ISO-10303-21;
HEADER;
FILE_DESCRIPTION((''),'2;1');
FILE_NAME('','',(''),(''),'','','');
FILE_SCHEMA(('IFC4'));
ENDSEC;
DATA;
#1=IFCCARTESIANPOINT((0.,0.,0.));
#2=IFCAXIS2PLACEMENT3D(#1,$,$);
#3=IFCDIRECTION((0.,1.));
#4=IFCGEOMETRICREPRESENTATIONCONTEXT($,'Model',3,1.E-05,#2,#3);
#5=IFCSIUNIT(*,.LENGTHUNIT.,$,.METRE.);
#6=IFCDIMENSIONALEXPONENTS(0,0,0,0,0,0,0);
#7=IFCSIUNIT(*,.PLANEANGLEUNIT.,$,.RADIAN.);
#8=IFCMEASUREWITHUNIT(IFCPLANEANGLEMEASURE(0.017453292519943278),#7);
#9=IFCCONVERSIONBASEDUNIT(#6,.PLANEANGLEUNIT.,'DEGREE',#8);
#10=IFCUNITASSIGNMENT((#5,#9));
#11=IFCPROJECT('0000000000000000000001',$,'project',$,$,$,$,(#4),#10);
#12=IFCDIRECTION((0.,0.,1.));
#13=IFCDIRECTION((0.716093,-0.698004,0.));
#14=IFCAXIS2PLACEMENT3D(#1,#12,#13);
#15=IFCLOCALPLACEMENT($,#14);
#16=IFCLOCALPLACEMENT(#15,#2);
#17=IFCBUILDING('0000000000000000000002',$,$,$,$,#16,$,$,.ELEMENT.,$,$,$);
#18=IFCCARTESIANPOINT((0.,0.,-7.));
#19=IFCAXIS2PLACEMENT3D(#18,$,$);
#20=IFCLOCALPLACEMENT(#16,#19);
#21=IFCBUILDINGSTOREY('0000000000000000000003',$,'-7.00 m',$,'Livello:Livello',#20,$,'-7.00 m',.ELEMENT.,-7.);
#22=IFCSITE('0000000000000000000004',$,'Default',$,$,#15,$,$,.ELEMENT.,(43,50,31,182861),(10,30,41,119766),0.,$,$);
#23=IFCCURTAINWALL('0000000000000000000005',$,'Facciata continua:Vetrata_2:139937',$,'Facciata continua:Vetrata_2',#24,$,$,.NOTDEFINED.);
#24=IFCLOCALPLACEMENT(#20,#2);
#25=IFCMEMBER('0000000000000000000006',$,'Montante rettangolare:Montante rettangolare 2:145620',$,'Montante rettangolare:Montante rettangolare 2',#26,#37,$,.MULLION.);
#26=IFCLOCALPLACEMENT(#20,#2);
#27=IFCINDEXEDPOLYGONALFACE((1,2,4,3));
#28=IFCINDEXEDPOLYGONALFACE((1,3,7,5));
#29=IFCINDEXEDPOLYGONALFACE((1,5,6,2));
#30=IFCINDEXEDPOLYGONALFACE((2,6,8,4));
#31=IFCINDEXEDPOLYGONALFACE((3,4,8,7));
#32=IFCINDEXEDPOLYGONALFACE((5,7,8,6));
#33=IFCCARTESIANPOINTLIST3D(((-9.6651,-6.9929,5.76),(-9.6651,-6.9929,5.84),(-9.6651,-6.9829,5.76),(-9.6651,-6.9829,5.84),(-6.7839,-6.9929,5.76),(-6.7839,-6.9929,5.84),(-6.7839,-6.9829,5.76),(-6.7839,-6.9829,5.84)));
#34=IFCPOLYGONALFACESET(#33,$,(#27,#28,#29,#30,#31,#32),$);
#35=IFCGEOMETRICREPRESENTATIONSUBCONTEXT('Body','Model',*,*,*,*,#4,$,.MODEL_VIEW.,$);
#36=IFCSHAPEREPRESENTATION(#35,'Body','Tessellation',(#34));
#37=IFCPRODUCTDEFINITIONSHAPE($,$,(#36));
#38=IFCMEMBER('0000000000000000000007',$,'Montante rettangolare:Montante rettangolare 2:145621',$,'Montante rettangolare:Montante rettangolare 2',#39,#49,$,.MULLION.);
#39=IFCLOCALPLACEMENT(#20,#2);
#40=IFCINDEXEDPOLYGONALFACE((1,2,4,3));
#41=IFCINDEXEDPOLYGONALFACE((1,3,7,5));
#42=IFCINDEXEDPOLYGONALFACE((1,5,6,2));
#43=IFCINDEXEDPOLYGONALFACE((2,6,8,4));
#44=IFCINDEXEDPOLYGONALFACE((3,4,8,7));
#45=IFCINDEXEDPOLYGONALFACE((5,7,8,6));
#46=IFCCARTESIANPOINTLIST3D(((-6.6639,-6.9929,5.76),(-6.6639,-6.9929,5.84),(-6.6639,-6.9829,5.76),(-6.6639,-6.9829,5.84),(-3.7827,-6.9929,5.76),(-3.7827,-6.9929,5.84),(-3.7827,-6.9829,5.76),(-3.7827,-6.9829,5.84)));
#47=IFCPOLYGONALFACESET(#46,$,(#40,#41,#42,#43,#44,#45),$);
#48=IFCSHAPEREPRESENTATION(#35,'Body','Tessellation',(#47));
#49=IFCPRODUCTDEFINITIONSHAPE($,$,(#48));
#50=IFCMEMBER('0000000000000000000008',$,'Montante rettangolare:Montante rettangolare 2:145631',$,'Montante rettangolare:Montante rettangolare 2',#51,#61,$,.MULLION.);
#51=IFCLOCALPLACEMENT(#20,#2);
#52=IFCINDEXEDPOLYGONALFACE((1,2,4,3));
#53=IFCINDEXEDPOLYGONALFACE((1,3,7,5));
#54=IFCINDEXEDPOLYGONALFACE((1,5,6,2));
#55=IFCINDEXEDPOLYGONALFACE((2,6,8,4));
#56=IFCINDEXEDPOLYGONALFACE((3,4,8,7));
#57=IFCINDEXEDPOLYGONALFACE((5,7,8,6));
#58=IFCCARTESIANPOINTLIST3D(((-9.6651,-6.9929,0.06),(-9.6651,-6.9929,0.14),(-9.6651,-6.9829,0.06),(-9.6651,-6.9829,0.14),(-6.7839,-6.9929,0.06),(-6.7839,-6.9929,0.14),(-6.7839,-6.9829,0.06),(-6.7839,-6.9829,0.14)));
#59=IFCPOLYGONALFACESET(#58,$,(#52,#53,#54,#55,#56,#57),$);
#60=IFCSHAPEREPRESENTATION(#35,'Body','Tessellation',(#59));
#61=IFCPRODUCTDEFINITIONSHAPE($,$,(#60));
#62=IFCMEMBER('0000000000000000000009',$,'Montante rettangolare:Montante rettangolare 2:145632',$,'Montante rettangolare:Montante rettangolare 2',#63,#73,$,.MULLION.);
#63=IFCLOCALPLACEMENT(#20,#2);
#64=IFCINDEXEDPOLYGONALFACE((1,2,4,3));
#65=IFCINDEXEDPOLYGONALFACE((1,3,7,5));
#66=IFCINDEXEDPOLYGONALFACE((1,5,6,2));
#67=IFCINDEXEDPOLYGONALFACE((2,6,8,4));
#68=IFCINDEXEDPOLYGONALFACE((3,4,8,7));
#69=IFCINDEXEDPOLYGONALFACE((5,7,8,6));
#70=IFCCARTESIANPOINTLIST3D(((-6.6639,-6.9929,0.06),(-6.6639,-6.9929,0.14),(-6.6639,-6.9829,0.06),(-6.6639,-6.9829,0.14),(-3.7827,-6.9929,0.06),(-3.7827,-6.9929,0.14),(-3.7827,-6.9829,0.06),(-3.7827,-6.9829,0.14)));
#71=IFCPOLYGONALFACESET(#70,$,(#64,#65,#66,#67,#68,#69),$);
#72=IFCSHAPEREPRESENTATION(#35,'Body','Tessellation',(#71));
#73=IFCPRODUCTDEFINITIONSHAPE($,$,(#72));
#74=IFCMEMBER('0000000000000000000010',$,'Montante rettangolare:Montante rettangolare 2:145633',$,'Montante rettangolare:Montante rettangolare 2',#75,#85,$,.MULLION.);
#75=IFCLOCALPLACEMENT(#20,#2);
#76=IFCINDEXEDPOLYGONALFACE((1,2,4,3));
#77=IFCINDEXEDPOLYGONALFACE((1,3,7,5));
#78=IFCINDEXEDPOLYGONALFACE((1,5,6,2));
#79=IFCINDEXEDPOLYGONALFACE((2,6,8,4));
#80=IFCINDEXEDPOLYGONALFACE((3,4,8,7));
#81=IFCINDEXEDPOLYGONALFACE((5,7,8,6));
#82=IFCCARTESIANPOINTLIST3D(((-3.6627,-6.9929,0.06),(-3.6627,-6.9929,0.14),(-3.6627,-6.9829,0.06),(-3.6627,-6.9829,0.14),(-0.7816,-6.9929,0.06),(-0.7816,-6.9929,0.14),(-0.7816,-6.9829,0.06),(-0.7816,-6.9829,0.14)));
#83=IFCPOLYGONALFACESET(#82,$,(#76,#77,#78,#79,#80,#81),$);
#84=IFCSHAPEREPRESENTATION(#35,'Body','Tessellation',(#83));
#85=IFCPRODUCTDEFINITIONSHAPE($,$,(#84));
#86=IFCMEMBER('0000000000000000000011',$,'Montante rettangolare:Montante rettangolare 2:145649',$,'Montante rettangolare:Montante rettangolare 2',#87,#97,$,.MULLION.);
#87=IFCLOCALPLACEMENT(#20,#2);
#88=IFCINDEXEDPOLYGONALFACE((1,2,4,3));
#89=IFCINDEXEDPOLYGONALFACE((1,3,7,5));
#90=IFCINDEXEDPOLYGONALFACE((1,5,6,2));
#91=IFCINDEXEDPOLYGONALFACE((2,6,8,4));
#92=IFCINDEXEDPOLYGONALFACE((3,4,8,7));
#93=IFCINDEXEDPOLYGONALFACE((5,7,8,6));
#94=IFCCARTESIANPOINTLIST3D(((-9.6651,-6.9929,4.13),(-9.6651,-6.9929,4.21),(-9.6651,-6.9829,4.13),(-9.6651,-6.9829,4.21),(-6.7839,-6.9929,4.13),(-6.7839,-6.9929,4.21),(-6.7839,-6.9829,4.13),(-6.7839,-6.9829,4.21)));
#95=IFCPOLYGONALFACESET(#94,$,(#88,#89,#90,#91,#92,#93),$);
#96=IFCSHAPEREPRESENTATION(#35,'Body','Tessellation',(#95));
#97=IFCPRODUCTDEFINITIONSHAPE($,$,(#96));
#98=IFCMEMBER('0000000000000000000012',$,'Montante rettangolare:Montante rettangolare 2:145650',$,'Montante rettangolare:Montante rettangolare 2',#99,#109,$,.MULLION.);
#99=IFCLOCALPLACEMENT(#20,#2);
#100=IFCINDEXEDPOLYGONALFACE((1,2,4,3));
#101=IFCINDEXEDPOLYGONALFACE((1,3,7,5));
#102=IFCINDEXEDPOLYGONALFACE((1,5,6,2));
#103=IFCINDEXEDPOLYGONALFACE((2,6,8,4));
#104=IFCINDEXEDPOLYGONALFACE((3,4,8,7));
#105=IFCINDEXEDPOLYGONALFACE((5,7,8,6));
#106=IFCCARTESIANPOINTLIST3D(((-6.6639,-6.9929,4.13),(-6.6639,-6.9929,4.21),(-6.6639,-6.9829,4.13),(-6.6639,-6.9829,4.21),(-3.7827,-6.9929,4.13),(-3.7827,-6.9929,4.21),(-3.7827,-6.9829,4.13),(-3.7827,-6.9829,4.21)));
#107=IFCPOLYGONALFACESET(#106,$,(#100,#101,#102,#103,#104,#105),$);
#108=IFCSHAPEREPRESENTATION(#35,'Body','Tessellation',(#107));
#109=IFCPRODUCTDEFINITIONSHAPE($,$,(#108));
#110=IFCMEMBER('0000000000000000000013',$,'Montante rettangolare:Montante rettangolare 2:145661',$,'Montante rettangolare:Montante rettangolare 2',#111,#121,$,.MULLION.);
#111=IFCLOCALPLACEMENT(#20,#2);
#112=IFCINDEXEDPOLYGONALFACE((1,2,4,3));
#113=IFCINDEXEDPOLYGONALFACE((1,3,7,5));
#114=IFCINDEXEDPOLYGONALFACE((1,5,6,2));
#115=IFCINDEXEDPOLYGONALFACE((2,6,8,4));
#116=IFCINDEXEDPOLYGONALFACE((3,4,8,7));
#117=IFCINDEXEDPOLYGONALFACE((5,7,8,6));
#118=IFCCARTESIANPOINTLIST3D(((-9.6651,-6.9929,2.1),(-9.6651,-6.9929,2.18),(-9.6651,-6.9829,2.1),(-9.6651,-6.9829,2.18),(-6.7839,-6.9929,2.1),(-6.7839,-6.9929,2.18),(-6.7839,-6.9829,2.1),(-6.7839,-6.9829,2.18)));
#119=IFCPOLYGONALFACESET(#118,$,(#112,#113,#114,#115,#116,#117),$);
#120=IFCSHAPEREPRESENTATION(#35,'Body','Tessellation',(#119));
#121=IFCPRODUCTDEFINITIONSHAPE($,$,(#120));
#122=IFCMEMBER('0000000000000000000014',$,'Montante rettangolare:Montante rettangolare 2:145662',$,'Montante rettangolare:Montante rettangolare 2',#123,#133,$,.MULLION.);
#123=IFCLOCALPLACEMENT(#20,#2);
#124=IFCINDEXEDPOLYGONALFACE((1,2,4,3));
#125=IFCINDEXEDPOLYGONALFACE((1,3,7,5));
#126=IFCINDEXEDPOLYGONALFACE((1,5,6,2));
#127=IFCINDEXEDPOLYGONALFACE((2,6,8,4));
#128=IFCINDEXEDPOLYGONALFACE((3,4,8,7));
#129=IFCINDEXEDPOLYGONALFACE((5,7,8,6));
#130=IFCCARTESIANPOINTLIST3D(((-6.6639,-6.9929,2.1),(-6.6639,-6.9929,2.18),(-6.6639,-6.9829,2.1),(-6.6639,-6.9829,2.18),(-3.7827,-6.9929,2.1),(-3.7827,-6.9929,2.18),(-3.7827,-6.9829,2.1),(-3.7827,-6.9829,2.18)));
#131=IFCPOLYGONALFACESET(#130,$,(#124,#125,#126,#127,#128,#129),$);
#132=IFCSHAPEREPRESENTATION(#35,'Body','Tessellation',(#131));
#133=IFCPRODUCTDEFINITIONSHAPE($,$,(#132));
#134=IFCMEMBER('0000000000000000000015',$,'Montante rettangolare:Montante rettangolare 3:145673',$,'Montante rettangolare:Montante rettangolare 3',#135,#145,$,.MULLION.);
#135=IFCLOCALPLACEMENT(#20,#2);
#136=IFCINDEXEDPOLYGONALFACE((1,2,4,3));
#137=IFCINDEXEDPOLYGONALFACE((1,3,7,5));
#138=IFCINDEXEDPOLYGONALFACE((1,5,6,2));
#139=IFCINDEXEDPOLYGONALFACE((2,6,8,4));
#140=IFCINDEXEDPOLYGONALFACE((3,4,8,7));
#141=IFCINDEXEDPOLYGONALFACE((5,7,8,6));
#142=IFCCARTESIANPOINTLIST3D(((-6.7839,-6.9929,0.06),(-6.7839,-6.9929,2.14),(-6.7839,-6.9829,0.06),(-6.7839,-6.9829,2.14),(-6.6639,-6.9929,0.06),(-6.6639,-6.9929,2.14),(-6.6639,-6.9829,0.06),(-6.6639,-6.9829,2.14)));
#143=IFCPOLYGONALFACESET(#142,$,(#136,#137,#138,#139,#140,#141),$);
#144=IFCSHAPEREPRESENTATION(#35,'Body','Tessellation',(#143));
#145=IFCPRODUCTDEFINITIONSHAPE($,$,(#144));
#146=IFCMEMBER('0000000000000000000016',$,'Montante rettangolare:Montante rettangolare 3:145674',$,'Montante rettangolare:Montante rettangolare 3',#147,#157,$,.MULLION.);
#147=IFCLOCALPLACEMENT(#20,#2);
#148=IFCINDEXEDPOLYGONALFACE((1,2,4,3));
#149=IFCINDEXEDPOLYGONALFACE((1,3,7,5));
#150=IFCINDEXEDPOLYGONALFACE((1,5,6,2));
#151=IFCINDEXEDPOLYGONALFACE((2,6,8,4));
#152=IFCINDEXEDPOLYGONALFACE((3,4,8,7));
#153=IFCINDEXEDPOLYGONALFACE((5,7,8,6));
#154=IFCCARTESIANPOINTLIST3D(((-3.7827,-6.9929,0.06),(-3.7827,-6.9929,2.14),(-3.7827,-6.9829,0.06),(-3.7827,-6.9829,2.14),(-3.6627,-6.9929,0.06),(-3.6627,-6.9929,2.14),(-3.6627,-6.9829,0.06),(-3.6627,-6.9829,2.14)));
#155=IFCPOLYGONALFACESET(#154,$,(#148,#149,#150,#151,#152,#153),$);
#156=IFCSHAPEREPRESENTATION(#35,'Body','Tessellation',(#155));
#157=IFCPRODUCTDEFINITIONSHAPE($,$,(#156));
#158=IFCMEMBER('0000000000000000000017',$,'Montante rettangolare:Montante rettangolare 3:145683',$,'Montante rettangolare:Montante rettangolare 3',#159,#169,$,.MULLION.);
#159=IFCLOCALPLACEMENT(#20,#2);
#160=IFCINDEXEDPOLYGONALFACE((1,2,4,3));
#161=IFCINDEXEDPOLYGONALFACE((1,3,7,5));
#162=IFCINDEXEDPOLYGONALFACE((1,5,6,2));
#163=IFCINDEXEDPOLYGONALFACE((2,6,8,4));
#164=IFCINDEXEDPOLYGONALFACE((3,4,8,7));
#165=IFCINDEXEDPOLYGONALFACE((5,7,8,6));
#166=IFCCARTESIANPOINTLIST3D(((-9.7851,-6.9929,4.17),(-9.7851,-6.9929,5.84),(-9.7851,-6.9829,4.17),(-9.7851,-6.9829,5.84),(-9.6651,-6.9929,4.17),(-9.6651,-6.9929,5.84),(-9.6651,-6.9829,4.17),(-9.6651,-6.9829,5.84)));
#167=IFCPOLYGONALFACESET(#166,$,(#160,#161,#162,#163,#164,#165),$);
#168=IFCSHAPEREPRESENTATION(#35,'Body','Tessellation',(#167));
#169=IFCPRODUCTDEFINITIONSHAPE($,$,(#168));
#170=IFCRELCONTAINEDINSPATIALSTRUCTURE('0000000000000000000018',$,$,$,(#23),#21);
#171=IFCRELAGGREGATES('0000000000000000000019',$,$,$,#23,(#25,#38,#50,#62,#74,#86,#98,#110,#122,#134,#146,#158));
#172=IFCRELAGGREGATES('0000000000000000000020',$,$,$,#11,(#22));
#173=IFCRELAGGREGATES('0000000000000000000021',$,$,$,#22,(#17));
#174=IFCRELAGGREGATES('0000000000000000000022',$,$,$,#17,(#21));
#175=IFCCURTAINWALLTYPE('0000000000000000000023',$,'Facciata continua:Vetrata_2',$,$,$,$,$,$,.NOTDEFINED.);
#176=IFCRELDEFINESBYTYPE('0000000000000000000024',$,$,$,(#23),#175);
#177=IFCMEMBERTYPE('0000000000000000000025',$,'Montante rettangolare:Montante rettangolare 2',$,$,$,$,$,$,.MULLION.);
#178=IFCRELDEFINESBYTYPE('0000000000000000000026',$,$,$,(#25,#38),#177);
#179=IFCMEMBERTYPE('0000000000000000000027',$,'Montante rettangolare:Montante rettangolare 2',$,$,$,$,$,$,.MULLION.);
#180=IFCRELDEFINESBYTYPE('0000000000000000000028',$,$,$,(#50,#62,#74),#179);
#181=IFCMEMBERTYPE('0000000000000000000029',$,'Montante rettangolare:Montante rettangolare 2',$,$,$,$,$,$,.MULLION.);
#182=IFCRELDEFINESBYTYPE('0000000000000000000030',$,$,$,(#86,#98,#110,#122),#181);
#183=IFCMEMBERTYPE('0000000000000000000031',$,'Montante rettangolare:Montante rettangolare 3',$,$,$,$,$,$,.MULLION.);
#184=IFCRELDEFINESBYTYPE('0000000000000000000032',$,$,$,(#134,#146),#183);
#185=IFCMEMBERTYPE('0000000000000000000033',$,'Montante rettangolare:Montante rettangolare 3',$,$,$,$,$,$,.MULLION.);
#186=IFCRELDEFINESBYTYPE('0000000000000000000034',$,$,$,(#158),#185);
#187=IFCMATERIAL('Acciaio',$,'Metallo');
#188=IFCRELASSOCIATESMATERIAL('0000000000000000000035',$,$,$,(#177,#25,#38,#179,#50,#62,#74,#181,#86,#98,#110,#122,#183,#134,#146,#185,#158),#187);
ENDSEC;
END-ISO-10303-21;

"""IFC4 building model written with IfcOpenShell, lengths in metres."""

from ifc_helpers import new_model, entity, si_unit, converted_unit, direction, frame, origin, place, context, subcontext, project, spatial, indexed_curve, outline, extrude, source, transform, mapped, material, type_object, type_shapes, element, aggregate, save


model = new_model("IFC4")

# Units and contexts
model_context = context("Model", 3, precision=1e-05, world=origin(), true_north=direction((0.0, 1.0)))
body_context = subcontext(model_context, "Body", "Model", "MODEL_VIEW")
ifc_project = project(units=[si_unit("LENGTHUNIT", "METRE"), converted_unit("PLANEANGLEUNIT", "DEGREE", entity("IfcPlaneAngleMeasure", 0.017453292519943278), si_unit("PLANEANGLEUNIT", "RADIAN"), dimensions=[0, 0, 0, 0, 0, 0, 0])], contexts=[model_context])

# Site, building, storey
site_placement = place(None, frame((0.0, 0.0, 0.0), z_axis=(0.0, 0.0, 1.0), x_axis=(0.716093, -0.698004, 0.0)))
site = spatial("IfcSite", under=ifc_project, at=site_placement, Name="Default", CompositionType="ELEMENT", RefLatitude=(43, 50, 31, 182861), RefLongitude=(10, 30, 41, 119766), RefElevation=0.0)
building_placement = place(site_placement, origin())
building = spatial("IfcBuilding", under=site, at=building_placement, CompositionType="ELEMENT")
storey_placement = place(building_placement, frame((0.0, 0.0, -7.0)))
storey = spatial("IfcBuildingStorey", under=building, at=storey_placement, Name="-7.00 m", ObjectType="Livello:Livello", LongName="-7.00 m", CompositionType="ELEMENT", Elevation=-7.0)

# Curtain wall, members
curtain_wall_type = type_object("IfcCurtainWallType", Name="Facciata continua:Vetrata_2", PredefinedType="NOTDEFINED")
curtain_wall_placement = place(storey_placement, frame((0.0, 0.0, 7.0)))
curtain_wall = element("IfcCurtainWall", 1, at=curtain_wall_placement, inside=storey, type_object=curtain_wall_type, Name="Facciata continua:Vetrata_2:139937", ObjectType="Facciata continua:Vetrata_2", PredefinedType="NOTDEFINED")
ifc_material_1 = material(Name="Acciaio", Category="Metallo")
member_type_1 = type_object("IfcMemberType", Name="Montante rettangolare:Montante rettangolare 2", PredefinedType="MULLION", material=ifc_material_1)
shared_shape_1 = source(origin(), body_context, "Body", "SweptSolid", [
    extrude(outline(indexed_curve([(-0.04, -0.005), (0.04, -0.005), (0.04, 0.005), (-0.04, 0.005), (-0.04, -0.005)], self_intersect=False)), frame((-0.04, 0.01, -2.8812), z_axis=(0.0, 0.0, 1.0), x_axis=(-1.0, 0.0, 0.0)), (0.0, 0.0, 1.0), 2.8812),
])
type_shapes(member_type_1, [shared_shape_1])
member_1_placement = place(curtain_wall_placement, frame((-6.7839, -6.9779, -1.16), z_axis=(1.0, 0.0, 0.0), x_axis=(0.0, 0.0, 1.0)))
member_1 = element("IfcMember", 2, at=member_1_placement, type_object=member_type_1, material=ifc_material_1, Name="Montante rettangolare:Montante rettangolare 2:145620", ObjectType="Montante rettangolare:Montante rettangolare 2", PredefinedType="MULLION", context=body_context, shape_type="MappedRepresentation", body=[
    mapped(shared_shape_1, transform((0.0, 0.0, 0.0), scale=1.0)),
])
member_2_placement = place(curtain_wall_placement, frame((-3.7827, -6.9779, -1.16), z_axis=(1.0, 0.0, 0.0), x_axis=(0.0, 0.0, 1.0)))
member_2 = element("IfcMember", 3, at=member_2_placement, type_object=member_type_1, material=ifc_material_1, Name="Montante rettangolare:Montante rettangolare 2:145621", ObjectType="Montante rettangolare:Montante rettangolare 2", PredefinedType="MULLION", context=body_context, shape_type="MappedRepresentation", body=[
    mapped(shared_shape_1, transform((0.0, 0.0, 0.0), scale=1.0)),
])
member_type_2 = type_object("IfcMemberType", Name="Montante rettangolare:Montante rettangolare 2", PredefinedType="MULLION", material=ifc_material_1)
shared_shape_2 = source(origin(), body_context, "Body", "SweptSolid", [
    extrude(outline(indexed_curve([(-0.04, -0.005), (0.04, -0.005), (0.04, 0.005), (-0.04, 0.005), (-0.04, -0.005)], self_intersect=False)), frame((-0.04, 0.01, -2.8812), z_axis=(0.0, 0.0, 1.0), x_axis=(-1.0, 0.0, 0.0)), (0.0, 0.0, 1.0), 2.8812),
])
type_shapes(member_type_2, [shared_shape_2])
member_3_placement = place(curtain_wall_placement, frame((-9.6651, -6.9779, -6.94), z_axis=(-1.0, 0.0, 0.0), x_axis=(0.0, 0.0, -1.0)))
member_3 = element("IfcMember", 4, at=member_3_placement, type_object=member_type_2, material=ifc_material_1, Name="Montante rettangolare:Montante rettangolare 2:145631", ObjectType="Montante rettangolare:Montante rettangolare 2", PredefinedType="MULLION", context=body_context, shape_type="MappedRepresentation", body=[
    mapped(shared_shape_2, transform((0.0, 0.0, 0.0), scale=1.0)),
])
member_4_placement = place(curtain_wall_placement, frame((-6.6639, -6.9779, -6.94), z_axis=(-1.0, 0.0, 0.0), x_axis=(0.0, 0.0, -1.0)))
member_4 = element("IfcMember", 5, at=member_4_placement, type_object=member_type_2, material=ifc_material_1, Name="Montante rettangolare:Montante rettangolare 2:145632", ObjectType="Montante rettangolare:Montante rettangolare 2", PredefinedType="MULLION", context=body_context, shape_type="MappedRepresentation", body=[
    mapped(shared_shape_2, transform((0.0, 0.0, 0.0), scale=1.0)),
])
member_5_placement = place(curtain_wall_placement, frame((-3.6627, -6.9779, -6.94), z_axis=(-1.0, 0.0, 0.0), x_axis=(0.0, 0.0, -1.0)))
member_5 = element("IfcMember", 6, at=member_5_placement, type_object=member_type_2, material=ifc_material_1, Name="Montante rettangolare:Montante rettangolare 2:145633", ObjectType="Montante rettangolare:Montante rettangolare 2", PredefinedType="MULLION", context=body_context, shape_type="MappedRepresentation", body=[
    mapped(shared_shape_2, transform((0.0, 0.0, 0.0), scale=1.0)),
])
member_type_3 = type_object("IfcMemberType", Name="Montante rettangolare:Montante rettangolare 2", PredefinedType="MULLION", material=ifc_material_1)
shared_shape_3 = source(origin(), body_context, "Body", "SweptSolid", [
    extrude(outline(indexed_curve([(-0.04, -0.005), (0.04, -0.005), (0.04, 0.005), (-0.04, 0.005), (-0.04, -0.005)], self_intersect=False)), frame((0.0, 0.01, -2.8812), z_axis=(0.0, 0.0, 1.0), x_axis=(-1.0, 0.0, 0.0)), (0.0, 0.0, 1.0), 2.8812),
])
type_shapes(member_type_3, [shared_shape_3])
member_6_placement = place(curtain_wall_placement, frame((-6.7839, -6.9779, -2.83), z_axis=(1.0, 0.0, 0.0), x_axis=(0.0, 0.0, 1.0)))
member_6 = element("IfcMember", 7, at=member_6_placement, type_object=member_type_3, material=ifc_material_1, Name="Montante rettangolare:Montante rettangolare 2:145649", ObjectType="Montante rettangolare:Montante rettangolare 2", PredefinedType="MULLION", context=body_context, shape_type="MappedRepresentation", body=[
    mapped(shared_shape_3, transform((0.0, 0.0, 0.0), scale=1.0)),
])
member_7_placement = place(curtain_wall_placement, frame((-3.7827, -6.9779, -2.83), z_axis=(1.0, 0.0, 0.0), x_axis=(0.0, 0.0, 1.0)))
member_7 = element("IfcMember", 8, at=member_7_placement, type_object=member_type_3, material=ifc_material_1, Name="Montante rettangolare:Montante rettangolare 2:145650", ObjectType="Montante rettangolare:Montante rettangolare 2", PredefinedType="MULLION", context=body_context, shape_type="MappedRepresentation", body=[
    mapped(shared_shape_3, transform((0.0, 0.0, 0.0), scale=1.0)),
])
member_8_placement = place(curtain_wall_placement, frame((-6.7839, -6.9779, -4.86), z_axis=(1.0, 0.0, 0.0), x_axis=(0.0, 0.0, 1.0)))
member_8 = element("IfcMember", 9, at=member_8_placement, type_object=member_type_3, material=ifc_material_1, Name="Montante rettangolare:Montante rettangolare 2:145661", ObjectType="Montante rettangolare:Montante rettangolare 2", PredefinedType="MULLION", context=body_context, shape_type="MappedRepresentation", body=[
    mapped(shared_shape_3, transform((0.0, 0.0, 0.0), scale=1.0)),
])
member_9_placement = place(curtain_wall_placement, frame((-3.7827, -6.9779, -4.86), z_axis=(1.0, 0.0, 0.0), x_axis=(0.0, 0.0, 1.0)))
member_9 = element("IfcMember", 10, at=member_9_placement, type_object=member_type_3, material=ifc_material_1, Name="Montante rettangolare:Montante rettangolare 2:145662", ObjectType="Montante rettangolare:Montante rettangolare 2", PredefinedType="MULLION", context=body_context, shape_type="MappedRepresentation", body=[
    mapped(shared_shape_3, transform((0.0, 0.0, 0.0), scale=1.0)),
])
member_type_4 = type_object("IfcMemberType", Name="Montante rettangolare:Montante rettangolare 3", PredefinedType="MULLION", material=ifc_material_1)
shared_shape_4 = source(origin(), body_context, "Body", "SweptSolid", [
    extrude(outline(indexed_curve([(-0.06, -0.005), (0.06, -0.005), (0.06, 0.005), (-0.06, 0.005), (-0.06, -0.005)], self_intersect=False)), frame((0.0, 0.01, -2.08), z_axis=(0.0, 0.0, 1.0), x_axis=(-1.0, 0.0, 0.0)), (0.0, 0.0, 1.0), 2.08),
])
type_shapes(member_type_4, [shared_shape_4])
member_10_placement = place(curtain_wall_placement, frame((-6.7239, -6.9779, -6.94), z_axis=(0.0, 0.0, -1.0), x_axis=(1.0, 0.0, 0.0)))
member_10 = element("IfcMember", 11, at=member_10_placement, type_object=member_type_4, material=ifc_material_1, Name="Montante rettangolare:Montante rettangolare 3:145673", ObjectType="Montante rettangolare:Montante rettangolare 3", PredefinedType="MULLION", context=body_context, shape_type="MappedRepresentation", body=[
    mapped(shared_shape_4, transform((0.0, 0.0, 0.0), scale=1.0)),
])
member_11_placement = place(curtain_wall_placement, frame((-3.7227, -6.9779, -6.94), z_axis=(0.0, 0.0, -1.0), x_axis=(1.0, 0.0, 0.0)))
member_11 = element("IfcMember", 12, at=member_11_placement, type_object=member_type_4, material=ifc_material_1, Name="Montante rettangolare:Montante rettangolare 3:145674", ObjectType="Montante rettangolare:Montante rettangolare 3", PredefinedType="MULLION", context=body_context, shape_type="MappedRepresentation", body=[
    mapped(shared_shape_4, transform((0.0, 0.0, 0.0), scale=1.0)),
])
member_type_5 = type_object("IfcMemberType", Name="Montante rettangolare:Montante rettangolare 3", PredefinedType="MULLION", material=ifc_material_1)
shared_shape_5 = source(origin(), body_context, "Body", "SweptSolid", [
    extrude(outline(indexed_curve([(-0.06, -0.005), (0.06, -0.005), (0.06, 0.005), (-0.06, 0.005), (-0.06, -0.005)], self_intersect=False)), frame((0.0, 0.01, -1.67), z_axis=(0.0, 0.0, 1.0), x_axis=(-1.0, 0.0, 0.0)), (0.0, 0.0, 1.0), 1.67),
])
type_shapes(member_type_5, [shared_shape_5])
member_12_placement = place(curtain_wall_placement, frame((-9.7251, -6.9779, -2.83), z_axis=(0.0, 0.0, -1.0), x_axis=(1.0, 0.0, 0.0)))
member_12 = element("IfcMember", 13, at=member_12_placement, type_object=member_type_5, material=ifc_material_1, Name="Montante rettangolare:Montante rettangolare 3:145683", ObjectType="Montante rettangolare:Montante rettangolare 3", PredefinedType="MULLION", context=body_context, shape_type="MappedRepresentation", body=[
    mapped(shared_shape_5, transform((0.0, 0.0, 0.0), scale=1.0)),
])
aggregate(curtain_wall, [member_1, member_2, member_3, member_4, member_5, member_6, member_7, member_8, member_9, member_10, member_11, member_12])

save(model, "model.ifc")
